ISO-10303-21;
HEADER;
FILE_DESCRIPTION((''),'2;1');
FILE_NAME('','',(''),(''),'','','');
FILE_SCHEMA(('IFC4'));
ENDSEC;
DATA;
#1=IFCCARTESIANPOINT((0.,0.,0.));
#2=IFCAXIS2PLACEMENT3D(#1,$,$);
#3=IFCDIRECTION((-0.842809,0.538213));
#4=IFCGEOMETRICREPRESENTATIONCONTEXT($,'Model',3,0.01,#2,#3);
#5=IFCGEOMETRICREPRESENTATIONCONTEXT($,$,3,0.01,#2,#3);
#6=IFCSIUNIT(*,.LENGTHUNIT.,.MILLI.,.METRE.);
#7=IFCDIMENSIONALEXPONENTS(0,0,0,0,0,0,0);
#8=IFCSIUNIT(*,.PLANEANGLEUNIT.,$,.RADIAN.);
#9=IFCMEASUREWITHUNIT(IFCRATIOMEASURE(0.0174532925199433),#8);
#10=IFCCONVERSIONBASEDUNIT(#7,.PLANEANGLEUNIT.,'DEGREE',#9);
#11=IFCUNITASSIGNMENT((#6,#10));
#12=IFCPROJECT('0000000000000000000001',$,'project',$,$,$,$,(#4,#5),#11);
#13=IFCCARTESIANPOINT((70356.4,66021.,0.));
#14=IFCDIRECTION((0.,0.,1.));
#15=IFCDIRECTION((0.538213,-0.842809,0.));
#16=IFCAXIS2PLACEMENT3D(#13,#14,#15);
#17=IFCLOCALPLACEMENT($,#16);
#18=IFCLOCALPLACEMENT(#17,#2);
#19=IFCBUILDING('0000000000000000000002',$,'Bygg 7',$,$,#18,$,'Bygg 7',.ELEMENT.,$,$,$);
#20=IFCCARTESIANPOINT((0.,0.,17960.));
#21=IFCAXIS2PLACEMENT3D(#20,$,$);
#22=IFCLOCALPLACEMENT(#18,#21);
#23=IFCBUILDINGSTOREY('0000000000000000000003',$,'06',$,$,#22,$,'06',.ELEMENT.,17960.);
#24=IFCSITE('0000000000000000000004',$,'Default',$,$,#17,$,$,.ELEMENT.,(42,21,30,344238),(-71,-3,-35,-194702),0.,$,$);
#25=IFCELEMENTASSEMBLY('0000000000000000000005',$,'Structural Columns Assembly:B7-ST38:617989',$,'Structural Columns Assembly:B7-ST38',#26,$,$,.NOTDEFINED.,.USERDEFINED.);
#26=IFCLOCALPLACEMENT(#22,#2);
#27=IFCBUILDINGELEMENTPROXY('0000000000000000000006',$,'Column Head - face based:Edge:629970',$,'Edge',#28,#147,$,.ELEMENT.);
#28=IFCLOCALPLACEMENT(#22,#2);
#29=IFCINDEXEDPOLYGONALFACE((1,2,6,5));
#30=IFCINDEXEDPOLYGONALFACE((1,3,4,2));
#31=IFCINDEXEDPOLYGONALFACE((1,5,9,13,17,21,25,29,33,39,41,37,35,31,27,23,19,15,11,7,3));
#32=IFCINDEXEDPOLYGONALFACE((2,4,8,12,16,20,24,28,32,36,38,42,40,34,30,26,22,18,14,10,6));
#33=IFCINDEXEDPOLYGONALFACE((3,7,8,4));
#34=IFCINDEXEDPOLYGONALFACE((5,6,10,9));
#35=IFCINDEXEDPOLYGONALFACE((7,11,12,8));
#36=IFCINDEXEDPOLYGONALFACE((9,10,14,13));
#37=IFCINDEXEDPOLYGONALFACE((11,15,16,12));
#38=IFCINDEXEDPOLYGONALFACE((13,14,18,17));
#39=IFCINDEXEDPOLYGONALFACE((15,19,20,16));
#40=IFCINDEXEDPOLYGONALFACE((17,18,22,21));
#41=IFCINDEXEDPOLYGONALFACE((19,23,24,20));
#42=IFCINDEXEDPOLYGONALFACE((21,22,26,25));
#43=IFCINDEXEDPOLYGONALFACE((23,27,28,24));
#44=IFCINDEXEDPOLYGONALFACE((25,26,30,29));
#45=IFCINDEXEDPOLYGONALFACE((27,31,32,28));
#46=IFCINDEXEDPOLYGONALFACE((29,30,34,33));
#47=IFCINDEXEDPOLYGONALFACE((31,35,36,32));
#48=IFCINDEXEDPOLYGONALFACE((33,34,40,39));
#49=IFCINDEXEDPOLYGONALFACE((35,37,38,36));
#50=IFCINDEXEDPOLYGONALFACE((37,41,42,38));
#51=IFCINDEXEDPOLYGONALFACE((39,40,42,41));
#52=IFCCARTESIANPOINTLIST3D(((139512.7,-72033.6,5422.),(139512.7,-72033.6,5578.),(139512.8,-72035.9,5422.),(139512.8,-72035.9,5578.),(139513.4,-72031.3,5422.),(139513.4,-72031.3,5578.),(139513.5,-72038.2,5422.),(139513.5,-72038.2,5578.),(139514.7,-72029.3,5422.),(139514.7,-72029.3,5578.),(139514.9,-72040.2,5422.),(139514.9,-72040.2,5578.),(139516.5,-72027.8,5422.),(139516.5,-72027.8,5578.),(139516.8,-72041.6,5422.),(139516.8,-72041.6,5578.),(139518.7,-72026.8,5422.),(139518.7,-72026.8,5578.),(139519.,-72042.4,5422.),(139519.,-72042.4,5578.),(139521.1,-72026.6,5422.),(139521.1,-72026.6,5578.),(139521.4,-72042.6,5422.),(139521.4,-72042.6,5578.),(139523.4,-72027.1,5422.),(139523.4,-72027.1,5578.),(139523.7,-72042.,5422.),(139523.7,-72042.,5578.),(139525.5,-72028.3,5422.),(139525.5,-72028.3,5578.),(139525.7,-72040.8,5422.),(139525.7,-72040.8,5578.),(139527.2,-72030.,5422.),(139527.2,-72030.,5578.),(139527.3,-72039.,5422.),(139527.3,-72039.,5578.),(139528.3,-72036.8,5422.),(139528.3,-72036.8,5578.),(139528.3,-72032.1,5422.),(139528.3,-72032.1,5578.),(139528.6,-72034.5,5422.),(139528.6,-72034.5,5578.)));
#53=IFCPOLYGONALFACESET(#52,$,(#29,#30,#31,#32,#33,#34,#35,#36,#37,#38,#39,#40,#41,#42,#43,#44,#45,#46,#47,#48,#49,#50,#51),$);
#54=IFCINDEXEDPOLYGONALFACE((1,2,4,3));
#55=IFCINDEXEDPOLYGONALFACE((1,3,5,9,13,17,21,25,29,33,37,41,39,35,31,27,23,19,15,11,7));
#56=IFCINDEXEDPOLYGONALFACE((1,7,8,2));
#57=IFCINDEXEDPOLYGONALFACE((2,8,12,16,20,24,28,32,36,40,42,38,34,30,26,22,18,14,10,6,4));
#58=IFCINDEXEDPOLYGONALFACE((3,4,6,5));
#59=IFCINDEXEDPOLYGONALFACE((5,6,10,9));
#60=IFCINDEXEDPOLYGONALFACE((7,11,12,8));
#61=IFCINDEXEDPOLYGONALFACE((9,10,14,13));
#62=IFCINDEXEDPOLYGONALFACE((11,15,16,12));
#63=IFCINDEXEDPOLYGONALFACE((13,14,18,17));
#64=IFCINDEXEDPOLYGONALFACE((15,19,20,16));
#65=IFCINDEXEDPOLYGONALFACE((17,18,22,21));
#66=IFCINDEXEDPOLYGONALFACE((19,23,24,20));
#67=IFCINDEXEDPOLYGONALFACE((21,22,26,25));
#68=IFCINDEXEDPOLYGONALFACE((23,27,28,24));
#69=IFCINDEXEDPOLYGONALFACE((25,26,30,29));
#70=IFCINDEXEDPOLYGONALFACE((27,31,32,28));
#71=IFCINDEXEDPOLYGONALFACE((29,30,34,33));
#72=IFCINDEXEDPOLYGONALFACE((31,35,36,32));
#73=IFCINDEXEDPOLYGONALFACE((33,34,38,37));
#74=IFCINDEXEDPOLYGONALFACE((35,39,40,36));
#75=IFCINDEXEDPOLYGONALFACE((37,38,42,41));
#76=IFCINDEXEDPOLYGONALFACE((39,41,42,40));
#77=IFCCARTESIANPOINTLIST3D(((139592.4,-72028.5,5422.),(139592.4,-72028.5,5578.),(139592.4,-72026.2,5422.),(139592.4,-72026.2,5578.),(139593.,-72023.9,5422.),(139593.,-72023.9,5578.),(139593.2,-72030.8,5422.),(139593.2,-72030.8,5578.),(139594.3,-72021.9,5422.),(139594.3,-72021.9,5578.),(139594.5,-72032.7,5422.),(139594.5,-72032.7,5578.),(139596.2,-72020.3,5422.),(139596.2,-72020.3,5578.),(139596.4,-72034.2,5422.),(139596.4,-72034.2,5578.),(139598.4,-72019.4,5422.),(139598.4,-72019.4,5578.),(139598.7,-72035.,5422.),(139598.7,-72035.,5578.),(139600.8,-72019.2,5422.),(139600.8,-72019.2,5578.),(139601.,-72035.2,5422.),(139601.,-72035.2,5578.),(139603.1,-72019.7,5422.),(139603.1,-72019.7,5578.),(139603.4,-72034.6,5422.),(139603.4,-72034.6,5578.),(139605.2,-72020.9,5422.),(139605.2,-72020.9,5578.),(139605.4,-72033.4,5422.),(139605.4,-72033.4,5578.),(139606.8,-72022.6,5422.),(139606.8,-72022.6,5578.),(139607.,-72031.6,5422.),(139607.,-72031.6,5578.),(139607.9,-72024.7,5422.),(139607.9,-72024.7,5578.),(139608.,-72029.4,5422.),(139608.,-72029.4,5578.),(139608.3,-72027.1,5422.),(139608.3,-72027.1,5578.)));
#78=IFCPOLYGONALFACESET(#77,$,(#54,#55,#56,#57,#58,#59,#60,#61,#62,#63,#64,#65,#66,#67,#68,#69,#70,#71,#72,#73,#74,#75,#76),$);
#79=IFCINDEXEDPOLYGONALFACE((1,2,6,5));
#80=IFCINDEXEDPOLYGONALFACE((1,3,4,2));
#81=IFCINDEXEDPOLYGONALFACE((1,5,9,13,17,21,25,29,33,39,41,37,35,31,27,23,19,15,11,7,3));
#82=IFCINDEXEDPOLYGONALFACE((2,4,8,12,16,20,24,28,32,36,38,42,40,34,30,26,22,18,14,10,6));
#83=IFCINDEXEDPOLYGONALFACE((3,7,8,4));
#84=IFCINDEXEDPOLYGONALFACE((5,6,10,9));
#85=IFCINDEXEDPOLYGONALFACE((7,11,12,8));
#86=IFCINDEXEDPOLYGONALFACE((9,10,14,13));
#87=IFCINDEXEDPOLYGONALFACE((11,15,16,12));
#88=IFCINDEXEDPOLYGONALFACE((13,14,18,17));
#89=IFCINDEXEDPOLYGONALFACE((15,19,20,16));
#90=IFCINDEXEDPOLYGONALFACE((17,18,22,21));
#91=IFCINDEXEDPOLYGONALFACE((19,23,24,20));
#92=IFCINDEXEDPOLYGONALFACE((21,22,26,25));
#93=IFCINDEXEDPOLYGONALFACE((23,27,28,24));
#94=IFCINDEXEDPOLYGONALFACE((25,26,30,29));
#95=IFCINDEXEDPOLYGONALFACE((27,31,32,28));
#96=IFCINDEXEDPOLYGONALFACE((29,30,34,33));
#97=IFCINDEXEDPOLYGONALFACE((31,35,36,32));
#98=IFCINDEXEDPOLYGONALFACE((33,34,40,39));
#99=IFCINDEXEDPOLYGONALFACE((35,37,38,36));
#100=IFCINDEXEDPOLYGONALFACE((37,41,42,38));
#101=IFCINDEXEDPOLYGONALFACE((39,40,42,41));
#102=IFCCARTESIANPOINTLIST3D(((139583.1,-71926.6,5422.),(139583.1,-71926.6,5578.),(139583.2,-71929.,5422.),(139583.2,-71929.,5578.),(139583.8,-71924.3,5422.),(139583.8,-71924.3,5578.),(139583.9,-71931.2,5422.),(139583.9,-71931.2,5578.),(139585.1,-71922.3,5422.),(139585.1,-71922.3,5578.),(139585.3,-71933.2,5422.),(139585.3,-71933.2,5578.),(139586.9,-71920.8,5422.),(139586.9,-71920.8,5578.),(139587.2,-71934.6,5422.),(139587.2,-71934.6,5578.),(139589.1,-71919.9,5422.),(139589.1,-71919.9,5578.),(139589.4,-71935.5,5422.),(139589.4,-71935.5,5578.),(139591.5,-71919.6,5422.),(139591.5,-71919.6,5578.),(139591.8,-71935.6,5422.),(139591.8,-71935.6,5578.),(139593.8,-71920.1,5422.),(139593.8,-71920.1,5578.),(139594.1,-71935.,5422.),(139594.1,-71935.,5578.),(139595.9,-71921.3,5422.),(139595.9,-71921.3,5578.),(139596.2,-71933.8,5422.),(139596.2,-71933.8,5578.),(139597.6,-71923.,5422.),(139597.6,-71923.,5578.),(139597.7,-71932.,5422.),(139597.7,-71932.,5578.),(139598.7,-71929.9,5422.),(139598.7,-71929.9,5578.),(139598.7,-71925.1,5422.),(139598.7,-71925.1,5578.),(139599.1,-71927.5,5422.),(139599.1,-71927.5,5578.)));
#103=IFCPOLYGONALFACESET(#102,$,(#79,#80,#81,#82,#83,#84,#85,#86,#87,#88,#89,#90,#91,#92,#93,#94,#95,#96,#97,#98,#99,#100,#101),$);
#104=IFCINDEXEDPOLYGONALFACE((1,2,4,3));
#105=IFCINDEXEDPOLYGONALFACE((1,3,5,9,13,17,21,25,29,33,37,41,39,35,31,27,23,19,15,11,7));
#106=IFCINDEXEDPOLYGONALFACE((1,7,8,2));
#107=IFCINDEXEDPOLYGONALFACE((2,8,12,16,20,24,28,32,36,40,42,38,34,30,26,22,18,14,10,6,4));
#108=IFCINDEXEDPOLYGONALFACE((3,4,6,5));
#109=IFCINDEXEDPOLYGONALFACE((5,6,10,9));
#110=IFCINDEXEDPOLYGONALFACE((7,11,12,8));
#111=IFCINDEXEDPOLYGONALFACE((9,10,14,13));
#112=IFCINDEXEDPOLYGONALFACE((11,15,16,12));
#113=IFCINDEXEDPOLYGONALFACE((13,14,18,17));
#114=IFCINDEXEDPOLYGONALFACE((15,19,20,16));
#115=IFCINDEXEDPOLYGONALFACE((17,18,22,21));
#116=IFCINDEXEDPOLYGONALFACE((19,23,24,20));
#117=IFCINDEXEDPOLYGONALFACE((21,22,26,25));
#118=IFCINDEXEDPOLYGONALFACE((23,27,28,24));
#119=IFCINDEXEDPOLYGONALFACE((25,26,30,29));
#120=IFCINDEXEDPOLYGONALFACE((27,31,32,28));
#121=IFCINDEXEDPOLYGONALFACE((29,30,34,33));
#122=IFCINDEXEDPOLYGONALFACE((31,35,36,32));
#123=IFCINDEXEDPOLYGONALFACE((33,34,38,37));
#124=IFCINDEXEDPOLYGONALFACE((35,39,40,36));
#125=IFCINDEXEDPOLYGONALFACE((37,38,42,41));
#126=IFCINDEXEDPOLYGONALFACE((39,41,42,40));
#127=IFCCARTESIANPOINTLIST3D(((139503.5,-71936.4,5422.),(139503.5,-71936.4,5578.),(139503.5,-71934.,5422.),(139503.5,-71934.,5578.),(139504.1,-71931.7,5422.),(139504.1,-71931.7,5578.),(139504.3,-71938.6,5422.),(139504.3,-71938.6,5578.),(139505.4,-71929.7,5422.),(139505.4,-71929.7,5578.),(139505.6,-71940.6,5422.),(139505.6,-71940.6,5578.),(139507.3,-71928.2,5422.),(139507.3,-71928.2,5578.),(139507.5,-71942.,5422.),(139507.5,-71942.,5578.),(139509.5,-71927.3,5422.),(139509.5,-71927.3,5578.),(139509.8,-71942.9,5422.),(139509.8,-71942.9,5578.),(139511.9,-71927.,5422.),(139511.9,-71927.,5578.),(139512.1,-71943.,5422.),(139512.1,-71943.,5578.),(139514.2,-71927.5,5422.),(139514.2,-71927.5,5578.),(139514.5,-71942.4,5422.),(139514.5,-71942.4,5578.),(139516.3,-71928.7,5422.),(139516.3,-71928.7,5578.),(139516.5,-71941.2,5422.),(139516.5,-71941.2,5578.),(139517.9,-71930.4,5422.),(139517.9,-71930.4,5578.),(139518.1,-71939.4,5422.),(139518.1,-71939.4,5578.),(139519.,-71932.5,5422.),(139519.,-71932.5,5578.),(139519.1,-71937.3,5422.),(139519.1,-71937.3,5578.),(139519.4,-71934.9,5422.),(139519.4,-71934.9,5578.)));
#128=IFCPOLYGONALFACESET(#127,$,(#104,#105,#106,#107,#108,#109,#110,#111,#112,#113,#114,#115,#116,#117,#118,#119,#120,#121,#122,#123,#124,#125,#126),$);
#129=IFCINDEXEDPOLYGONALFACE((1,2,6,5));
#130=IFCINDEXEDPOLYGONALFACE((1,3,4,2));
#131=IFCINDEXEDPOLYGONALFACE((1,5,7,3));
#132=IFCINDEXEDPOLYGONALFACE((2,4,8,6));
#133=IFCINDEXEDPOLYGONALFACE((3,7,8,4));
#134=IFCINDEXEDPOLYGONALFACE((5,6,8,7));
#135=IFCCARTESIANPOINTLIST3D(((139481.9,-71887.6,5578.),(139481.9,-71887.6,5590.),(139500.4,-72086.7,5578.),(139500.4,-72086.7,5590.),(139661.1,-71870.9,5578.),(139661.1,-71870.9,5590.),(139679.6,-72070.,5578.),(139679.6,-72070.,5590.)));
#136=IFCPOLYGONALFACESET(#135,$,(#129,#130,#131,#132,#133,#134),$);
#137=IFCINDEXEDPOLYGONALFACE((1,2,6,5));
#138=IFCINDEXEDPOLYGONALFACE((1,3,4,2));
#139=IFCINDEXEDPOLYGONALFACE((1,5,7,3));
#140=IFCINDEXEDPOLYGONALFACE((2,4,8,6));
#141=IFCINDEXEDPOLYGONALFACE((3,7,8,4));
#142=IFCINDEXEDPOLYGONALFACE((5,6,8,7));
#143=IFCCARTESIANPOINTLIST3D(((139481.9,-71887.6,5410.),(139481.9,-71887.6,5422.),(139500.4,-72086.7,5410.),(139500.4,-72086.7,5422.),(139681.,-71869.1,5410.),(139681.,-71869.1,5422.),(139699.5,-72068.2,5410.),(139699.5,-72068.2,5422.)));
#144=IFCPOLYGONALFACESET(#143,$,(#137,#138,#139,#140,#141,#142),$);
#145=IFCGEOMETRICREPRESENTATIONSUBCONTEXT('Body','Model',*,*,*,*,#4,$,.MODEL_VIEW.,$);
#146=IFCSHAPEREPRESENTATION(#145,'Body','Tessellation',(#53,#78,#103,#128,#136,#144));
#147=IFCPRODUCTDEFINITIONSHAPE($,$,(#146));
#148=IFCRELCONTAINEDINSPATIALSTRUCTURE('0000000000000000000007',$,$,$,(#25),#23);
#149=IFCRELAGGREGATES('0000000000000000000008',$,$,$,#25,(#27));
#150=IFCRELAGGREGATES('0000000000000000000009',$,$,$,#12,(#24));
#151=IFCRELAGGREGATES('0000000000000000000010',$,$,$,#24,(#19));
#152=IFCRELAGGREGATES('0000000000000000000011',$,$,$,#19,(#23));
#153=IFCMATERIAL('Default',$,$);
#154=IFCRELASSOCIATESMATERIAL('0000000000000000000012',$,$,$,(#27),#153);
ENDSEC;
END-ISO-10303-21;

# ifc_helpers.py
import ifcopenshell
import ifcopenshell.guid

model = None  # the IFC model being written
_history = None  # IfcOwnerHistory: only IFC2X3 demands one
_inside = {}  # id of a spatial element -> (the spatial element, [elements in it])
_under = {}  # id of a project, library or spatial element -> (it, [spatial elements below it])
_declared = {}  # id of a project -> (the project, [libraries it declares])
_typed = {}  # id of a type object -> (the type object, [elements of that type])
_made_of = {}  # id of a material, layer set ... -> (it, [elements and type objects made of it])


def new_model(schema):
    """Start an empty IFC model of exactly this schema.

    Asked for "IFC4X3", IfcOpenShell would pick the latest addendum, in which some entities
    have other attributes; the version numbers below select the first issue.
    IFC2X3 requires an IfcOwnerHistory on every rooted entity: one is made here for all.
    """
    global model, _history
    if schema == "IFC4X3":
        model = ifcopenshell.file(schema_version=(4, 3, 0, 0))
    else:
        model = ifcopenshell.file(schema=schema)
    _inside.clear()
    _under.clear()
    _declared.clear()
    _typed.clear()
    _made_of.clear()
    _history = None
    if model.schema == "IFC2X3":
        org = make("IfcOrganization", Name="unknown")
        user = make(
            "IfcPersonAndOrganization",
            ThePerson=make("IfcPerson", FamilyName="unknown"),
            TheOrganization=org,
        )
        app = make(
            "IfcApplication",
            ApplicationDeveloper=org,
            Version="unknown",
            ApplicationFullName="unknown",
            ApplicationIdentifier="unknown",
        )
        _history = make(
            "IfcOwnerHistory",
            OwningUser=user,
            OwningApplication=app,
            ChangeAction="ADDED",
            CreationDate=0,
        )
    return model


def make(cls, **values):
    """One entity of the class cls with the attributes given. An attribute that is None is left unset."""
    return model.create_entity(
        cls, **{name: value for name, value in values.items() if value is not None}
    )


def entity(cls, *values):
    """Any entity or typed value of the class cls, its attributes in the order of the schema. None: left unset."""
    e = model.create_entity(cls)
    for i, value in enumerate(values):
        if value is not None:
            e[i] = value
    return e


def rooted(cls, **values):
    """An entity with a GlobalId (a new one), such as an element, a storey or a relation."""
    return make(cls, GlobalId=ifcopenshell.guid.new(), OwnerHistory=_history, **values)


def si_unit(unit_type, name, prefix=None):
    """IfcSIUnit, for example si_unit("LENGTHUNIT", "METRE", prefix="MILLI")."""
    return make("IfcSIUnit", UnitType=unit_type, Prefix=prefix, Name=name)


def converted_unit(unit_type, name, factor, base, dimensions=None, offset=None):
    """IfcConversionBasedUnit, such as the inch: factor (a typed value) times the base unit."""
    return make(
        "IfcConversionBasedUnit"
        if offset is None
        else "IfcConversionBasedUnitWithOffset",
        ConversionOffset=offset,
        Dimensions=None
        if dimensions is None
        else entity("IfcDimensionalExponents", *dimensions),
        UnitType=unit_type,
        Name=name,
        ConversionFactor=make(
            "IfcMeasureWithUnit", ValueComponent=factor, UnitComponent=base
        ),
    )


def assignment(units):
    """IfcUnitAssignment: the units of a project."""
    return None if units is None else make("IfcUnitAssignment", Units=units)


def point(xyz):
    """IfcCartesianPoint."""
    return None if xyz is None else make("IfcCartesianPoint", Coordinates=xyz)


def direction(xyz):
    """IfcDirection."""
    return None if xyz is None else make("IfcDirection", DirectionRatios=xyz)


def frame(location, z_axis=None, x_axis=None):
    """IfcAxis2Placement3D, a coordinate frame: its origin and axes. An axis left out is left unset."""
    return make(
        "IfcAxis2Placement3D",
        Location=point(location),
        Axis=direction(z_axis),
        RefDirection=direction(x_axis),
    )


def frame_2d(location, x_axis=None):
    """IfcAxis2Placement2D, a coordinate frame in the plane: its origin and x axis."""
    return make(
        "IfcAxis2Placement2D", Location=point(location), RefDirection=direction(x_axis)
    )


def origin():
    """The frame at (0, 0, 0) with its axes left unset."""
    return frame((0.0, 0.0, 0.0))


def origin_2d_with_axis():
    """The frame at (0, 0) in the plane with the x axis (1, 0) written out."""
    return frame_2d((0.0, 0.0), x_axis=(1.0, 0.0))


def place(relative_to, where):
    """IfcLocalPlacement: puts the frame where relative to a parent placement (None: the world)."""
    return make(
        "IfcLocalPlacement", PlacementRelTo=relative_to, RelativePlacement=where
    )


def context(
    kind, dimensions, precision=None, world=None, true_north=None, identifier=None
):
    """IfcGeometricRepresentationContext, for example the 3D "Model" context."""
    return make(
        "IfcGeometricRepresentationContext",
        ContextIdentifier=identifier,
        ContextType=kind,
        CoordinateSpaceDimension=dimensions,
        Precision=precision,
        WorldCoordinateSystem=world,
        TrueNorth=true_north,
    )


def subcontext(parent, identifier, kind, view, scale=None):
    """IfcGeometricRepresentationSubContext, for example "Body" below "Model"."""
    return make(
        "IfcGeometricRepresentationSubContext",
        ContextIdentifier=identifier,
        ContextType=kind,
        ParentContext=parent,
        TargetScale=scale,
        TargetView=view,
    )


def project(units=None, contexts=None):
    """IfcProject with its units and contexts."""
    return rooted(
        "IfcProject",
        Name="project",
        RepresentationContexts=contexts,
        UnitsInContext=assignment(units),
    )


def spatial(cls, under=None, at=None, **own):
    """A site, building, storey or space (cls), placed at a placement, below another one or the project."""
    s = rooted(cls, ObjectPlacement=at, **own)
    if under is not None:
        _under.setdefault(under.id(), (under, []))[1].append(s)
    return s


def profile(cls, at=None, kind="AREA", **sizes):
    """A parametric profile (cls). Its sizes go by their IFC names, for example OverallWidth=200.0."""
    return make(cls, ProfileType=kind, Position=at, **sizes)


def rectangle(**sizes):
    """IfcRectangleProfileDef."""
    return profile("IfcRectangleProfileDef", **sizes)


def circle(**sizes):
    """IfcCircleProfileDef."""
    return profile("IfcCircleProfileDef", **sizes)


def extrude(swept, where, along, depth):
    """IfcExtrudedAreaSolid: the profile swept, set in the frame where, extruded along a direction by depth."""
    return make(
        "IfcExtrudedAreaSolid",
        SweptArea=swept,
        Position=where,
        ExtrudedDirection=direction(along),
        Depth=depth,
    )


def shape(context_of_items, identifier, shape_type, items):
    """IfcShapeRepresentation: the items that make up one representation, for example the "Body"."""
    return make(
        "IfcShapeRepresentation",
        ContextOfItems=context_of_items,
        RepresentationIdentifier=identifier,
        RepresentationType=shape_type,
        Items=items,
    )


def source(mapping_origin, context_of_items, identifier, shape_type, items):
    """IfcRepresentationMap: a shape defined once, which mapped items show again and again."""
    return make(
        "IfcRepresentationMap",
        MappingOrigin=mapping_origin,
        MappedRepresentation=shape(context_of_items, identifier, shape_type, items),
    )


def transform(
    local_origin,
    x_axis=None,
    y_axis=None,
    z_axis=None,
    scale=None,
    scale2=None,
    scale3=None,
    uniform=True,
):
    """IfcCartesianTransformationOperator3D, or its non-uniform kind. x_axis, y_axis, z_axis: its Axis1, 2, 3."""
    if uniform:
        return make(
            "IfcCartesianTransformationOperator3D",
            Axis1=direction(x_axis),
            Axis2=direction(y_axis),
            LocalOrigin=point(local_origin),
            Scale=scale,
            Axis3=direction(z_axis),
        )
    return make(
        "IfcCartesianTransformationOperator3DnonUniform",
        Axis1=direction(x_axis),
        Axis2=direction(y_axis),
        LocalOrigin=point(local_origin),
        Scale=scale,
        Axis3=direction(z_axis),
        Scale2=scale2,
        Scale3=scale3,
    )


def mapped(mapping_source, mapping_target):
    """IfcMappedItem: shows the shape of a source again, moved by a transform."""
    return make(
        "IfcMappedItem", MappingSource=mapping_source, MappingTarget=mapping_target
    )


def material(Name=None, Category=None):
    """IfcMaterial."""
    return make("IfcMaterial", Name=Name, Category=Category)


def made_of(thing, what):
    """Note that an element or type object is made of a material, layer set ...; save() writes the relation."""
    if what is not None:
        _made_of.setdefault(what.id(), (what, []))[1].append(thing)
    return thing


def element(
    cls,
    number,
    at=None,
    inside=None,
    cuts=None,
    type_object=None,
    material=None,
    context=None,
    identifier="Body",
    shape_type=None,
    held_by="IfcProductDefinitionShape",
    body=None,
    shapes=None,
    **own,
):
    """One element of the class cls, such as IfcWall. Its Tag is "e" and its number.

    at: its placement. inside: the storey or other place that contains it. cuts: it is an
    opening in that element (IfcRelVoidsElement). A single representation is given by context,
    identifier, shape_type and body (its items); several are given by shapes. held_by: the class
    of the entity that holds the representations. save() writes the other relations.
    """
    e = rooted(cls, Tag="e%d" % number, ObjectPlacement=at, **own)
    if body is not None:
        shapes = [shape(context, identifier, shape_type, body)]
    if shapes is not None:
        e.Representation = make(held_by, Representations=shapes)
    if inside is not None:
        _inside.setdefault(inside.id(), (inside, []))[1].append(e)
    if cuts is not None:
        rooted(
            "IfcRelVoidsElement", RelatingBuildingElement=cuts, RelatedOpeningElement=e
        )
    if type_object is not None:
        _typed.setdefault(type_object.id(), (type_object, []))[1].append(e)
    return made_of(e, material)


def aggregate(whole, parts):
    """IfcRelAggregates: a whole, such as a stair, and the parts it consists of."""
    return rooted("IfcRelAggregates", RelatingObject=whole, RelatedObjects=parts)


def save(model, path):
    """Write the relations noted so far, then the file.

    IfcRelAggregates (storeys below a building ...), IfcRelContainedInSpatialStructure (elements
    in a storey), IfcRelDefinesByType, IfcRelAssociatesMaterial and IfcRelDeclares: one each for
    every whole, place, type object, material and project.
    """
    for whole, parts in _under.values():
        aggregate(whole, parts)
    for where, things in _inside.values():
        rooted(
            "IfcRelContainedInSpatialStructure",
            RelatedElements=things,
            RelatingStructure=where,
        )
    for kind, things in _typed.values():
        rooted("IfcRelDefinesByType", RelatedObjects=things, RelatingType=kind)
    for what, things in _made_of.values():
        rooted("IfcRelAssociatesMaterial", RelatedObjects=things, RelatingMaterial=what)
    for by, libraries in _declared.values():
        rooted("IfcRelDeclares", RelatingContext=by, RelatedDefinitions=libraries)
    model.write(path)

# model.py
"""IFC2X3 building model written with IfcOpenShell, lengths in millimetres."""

from ifc_helpers import new_model, entity, si_unit, converted_unit, direction, frame, frame_2d, origin, origin_2d_with_axis, place, context, subcontext, project, spatial, rectangle, circle, extrude, source, transform, mapped, material, element, aggregate, save


model = new_model("IFC2X3")

# Units and contexts
model_context = context("Model", 3, precision=0.01, world=origin(), true_north=direction((-0.842809, 0.538213)))
context_of_model = context(None, 3, precision=0.01, world=origin(), true_north=direction((-0.842809, 0.538213)))
body_context = subcontext(model_context, "Body", "Model", "MODEL_VIEW")
ifc_project = project(units=[si_unit("LENGTHUNIT", "METRE", prefix="MILLI"), converted_unit("PLANEANGLEUNIT", "DEGREE", entity("IfcRatioMeasure", 0.0174532925199433), si_unit("PLANEANGLEUNIT", "RADIAN"), dimensions=[0, 0, 0, 0, 0, 0, 0])], contexts=[model_context, context_of_model])

# Site, building, storey
site_placement = place(None, frame((70356.4, 66021.0, 0.0), z_axis=(0.0, 0.0, 1.0), x_axis=(0.538213, -0.842809, 0.0)))
site = spatial("IfcSite", under=ifc_project, at=site_placement, Name="Default", CompositionType="ELEMENT", RefLatitude=(42, 21, 30, 344238), RefLongitude=(-71, -3, -35, -194702), RefElevation=0.0)
building_placement = place(site_placement, origin())
building = spatial("IfcBuilding", under=site, at=building_placement, Name="Bygg 7", LongName="Bygg 7", CompositionType="ELEMENT")
storey_placement = place(building_placement, frame((0.0, 0.0, 17960.0)))
storey = spatial("IfcBuildingStorey", under=building, at=storey_placement, Name="06", LongName="06", CompositionType="ELEMENT", Elevation=17960.0)

# Shared definitions
ifc_material_1 = material(Name="Default")

# Element assembly, building element proxy
shared_shape_1 = source(origin(), body_context, "Body", "SweptSolid", [
    extrude(circle(Radius=8.0, at=frame_2d((0.0, 0.0), x_axis=(1.0, 0.0))), frame((50.0, -135.0, 12.0)), (0.0, 0.0, 1.0), 156.0),
    extrude(circle(Radius=8.0, at=frame_2d((0.0, 0.0), x_axis=(1.0, 0.0))), frame((50.0, -55.0, 12.0)), (0.0, 0.0, 1.0), 156.0),
    extrude(circle(Radius=8.0, at=frame_2d((0.0, 0.0), x_axis=(1.0, 0.0))), frame((-50.0, -55.0, 12.0)), (0.0, 0.0, 1.0), 156.0),
    extrude(circle(Radius=8.0, at=frame_2d((0.0, 0.0), x_axis=(1.0, 0.0))), frame((-50.0, -135.0, 12.0)), (0.0, 0.0, 1.0), 156.0),
    extrude(rectangle(XDim=200.0, YDim=180.0, at=origin_2d_with_axis()), frame((0.0, -70.0, 168.0), z_axis=(0.0, 0.0, 1.0), x_axis=(-1.0, 0.0, 0.0)), (0.0, 0.0, 1.0), 12.0),
    extrude(rectangle(XDim=200.0, YDim=200.0, at=origin_2d_with_axis()), frame((0.0, -60.0, 0.0), z_axis=(0.0, 0.0, 1.0), x_axis=(0.0, 1.0, 0.0)), (0.0, 0.0, 1.0), 12.0),
])
assembly_1_placement = place(storey_placement, origin())
assembly_1 = element("IfcElementAssembly", 1, at=assembly_1_placement, inside=storey, Name="Structural Columns Assembly:B7-ST38:617989", ObjectType="Structural Columns Assembly:B7-ST38", AssemblyPlace="NOTDEFINED", PredefinedType="USERDEFINED")
proxy_1_placement = place(assembly_1_placement, frame((139650.4, -71972.3, 5410.0), z_axis=(0.0, 0.0, 1.0), x_axis=(0.092529, -0.99571, 0.0)))
proxy_1 = element("IfcBuildingElementProxy", 2, at=proxy_1_placement, material=ifc_material_1, Name="Column Head - face based:Edge:629970", ObjectType="Edge", CompositionType="ELEMENT", context=body_context, shape_type="MappedRepresentation", body=[
    mapped(shared_shape_1, transform((0.0, 0.0, 0.0), scale=1.0)),
])
aggregate(assembly_1, [proxy_1])

save(model, "model.ifc")
